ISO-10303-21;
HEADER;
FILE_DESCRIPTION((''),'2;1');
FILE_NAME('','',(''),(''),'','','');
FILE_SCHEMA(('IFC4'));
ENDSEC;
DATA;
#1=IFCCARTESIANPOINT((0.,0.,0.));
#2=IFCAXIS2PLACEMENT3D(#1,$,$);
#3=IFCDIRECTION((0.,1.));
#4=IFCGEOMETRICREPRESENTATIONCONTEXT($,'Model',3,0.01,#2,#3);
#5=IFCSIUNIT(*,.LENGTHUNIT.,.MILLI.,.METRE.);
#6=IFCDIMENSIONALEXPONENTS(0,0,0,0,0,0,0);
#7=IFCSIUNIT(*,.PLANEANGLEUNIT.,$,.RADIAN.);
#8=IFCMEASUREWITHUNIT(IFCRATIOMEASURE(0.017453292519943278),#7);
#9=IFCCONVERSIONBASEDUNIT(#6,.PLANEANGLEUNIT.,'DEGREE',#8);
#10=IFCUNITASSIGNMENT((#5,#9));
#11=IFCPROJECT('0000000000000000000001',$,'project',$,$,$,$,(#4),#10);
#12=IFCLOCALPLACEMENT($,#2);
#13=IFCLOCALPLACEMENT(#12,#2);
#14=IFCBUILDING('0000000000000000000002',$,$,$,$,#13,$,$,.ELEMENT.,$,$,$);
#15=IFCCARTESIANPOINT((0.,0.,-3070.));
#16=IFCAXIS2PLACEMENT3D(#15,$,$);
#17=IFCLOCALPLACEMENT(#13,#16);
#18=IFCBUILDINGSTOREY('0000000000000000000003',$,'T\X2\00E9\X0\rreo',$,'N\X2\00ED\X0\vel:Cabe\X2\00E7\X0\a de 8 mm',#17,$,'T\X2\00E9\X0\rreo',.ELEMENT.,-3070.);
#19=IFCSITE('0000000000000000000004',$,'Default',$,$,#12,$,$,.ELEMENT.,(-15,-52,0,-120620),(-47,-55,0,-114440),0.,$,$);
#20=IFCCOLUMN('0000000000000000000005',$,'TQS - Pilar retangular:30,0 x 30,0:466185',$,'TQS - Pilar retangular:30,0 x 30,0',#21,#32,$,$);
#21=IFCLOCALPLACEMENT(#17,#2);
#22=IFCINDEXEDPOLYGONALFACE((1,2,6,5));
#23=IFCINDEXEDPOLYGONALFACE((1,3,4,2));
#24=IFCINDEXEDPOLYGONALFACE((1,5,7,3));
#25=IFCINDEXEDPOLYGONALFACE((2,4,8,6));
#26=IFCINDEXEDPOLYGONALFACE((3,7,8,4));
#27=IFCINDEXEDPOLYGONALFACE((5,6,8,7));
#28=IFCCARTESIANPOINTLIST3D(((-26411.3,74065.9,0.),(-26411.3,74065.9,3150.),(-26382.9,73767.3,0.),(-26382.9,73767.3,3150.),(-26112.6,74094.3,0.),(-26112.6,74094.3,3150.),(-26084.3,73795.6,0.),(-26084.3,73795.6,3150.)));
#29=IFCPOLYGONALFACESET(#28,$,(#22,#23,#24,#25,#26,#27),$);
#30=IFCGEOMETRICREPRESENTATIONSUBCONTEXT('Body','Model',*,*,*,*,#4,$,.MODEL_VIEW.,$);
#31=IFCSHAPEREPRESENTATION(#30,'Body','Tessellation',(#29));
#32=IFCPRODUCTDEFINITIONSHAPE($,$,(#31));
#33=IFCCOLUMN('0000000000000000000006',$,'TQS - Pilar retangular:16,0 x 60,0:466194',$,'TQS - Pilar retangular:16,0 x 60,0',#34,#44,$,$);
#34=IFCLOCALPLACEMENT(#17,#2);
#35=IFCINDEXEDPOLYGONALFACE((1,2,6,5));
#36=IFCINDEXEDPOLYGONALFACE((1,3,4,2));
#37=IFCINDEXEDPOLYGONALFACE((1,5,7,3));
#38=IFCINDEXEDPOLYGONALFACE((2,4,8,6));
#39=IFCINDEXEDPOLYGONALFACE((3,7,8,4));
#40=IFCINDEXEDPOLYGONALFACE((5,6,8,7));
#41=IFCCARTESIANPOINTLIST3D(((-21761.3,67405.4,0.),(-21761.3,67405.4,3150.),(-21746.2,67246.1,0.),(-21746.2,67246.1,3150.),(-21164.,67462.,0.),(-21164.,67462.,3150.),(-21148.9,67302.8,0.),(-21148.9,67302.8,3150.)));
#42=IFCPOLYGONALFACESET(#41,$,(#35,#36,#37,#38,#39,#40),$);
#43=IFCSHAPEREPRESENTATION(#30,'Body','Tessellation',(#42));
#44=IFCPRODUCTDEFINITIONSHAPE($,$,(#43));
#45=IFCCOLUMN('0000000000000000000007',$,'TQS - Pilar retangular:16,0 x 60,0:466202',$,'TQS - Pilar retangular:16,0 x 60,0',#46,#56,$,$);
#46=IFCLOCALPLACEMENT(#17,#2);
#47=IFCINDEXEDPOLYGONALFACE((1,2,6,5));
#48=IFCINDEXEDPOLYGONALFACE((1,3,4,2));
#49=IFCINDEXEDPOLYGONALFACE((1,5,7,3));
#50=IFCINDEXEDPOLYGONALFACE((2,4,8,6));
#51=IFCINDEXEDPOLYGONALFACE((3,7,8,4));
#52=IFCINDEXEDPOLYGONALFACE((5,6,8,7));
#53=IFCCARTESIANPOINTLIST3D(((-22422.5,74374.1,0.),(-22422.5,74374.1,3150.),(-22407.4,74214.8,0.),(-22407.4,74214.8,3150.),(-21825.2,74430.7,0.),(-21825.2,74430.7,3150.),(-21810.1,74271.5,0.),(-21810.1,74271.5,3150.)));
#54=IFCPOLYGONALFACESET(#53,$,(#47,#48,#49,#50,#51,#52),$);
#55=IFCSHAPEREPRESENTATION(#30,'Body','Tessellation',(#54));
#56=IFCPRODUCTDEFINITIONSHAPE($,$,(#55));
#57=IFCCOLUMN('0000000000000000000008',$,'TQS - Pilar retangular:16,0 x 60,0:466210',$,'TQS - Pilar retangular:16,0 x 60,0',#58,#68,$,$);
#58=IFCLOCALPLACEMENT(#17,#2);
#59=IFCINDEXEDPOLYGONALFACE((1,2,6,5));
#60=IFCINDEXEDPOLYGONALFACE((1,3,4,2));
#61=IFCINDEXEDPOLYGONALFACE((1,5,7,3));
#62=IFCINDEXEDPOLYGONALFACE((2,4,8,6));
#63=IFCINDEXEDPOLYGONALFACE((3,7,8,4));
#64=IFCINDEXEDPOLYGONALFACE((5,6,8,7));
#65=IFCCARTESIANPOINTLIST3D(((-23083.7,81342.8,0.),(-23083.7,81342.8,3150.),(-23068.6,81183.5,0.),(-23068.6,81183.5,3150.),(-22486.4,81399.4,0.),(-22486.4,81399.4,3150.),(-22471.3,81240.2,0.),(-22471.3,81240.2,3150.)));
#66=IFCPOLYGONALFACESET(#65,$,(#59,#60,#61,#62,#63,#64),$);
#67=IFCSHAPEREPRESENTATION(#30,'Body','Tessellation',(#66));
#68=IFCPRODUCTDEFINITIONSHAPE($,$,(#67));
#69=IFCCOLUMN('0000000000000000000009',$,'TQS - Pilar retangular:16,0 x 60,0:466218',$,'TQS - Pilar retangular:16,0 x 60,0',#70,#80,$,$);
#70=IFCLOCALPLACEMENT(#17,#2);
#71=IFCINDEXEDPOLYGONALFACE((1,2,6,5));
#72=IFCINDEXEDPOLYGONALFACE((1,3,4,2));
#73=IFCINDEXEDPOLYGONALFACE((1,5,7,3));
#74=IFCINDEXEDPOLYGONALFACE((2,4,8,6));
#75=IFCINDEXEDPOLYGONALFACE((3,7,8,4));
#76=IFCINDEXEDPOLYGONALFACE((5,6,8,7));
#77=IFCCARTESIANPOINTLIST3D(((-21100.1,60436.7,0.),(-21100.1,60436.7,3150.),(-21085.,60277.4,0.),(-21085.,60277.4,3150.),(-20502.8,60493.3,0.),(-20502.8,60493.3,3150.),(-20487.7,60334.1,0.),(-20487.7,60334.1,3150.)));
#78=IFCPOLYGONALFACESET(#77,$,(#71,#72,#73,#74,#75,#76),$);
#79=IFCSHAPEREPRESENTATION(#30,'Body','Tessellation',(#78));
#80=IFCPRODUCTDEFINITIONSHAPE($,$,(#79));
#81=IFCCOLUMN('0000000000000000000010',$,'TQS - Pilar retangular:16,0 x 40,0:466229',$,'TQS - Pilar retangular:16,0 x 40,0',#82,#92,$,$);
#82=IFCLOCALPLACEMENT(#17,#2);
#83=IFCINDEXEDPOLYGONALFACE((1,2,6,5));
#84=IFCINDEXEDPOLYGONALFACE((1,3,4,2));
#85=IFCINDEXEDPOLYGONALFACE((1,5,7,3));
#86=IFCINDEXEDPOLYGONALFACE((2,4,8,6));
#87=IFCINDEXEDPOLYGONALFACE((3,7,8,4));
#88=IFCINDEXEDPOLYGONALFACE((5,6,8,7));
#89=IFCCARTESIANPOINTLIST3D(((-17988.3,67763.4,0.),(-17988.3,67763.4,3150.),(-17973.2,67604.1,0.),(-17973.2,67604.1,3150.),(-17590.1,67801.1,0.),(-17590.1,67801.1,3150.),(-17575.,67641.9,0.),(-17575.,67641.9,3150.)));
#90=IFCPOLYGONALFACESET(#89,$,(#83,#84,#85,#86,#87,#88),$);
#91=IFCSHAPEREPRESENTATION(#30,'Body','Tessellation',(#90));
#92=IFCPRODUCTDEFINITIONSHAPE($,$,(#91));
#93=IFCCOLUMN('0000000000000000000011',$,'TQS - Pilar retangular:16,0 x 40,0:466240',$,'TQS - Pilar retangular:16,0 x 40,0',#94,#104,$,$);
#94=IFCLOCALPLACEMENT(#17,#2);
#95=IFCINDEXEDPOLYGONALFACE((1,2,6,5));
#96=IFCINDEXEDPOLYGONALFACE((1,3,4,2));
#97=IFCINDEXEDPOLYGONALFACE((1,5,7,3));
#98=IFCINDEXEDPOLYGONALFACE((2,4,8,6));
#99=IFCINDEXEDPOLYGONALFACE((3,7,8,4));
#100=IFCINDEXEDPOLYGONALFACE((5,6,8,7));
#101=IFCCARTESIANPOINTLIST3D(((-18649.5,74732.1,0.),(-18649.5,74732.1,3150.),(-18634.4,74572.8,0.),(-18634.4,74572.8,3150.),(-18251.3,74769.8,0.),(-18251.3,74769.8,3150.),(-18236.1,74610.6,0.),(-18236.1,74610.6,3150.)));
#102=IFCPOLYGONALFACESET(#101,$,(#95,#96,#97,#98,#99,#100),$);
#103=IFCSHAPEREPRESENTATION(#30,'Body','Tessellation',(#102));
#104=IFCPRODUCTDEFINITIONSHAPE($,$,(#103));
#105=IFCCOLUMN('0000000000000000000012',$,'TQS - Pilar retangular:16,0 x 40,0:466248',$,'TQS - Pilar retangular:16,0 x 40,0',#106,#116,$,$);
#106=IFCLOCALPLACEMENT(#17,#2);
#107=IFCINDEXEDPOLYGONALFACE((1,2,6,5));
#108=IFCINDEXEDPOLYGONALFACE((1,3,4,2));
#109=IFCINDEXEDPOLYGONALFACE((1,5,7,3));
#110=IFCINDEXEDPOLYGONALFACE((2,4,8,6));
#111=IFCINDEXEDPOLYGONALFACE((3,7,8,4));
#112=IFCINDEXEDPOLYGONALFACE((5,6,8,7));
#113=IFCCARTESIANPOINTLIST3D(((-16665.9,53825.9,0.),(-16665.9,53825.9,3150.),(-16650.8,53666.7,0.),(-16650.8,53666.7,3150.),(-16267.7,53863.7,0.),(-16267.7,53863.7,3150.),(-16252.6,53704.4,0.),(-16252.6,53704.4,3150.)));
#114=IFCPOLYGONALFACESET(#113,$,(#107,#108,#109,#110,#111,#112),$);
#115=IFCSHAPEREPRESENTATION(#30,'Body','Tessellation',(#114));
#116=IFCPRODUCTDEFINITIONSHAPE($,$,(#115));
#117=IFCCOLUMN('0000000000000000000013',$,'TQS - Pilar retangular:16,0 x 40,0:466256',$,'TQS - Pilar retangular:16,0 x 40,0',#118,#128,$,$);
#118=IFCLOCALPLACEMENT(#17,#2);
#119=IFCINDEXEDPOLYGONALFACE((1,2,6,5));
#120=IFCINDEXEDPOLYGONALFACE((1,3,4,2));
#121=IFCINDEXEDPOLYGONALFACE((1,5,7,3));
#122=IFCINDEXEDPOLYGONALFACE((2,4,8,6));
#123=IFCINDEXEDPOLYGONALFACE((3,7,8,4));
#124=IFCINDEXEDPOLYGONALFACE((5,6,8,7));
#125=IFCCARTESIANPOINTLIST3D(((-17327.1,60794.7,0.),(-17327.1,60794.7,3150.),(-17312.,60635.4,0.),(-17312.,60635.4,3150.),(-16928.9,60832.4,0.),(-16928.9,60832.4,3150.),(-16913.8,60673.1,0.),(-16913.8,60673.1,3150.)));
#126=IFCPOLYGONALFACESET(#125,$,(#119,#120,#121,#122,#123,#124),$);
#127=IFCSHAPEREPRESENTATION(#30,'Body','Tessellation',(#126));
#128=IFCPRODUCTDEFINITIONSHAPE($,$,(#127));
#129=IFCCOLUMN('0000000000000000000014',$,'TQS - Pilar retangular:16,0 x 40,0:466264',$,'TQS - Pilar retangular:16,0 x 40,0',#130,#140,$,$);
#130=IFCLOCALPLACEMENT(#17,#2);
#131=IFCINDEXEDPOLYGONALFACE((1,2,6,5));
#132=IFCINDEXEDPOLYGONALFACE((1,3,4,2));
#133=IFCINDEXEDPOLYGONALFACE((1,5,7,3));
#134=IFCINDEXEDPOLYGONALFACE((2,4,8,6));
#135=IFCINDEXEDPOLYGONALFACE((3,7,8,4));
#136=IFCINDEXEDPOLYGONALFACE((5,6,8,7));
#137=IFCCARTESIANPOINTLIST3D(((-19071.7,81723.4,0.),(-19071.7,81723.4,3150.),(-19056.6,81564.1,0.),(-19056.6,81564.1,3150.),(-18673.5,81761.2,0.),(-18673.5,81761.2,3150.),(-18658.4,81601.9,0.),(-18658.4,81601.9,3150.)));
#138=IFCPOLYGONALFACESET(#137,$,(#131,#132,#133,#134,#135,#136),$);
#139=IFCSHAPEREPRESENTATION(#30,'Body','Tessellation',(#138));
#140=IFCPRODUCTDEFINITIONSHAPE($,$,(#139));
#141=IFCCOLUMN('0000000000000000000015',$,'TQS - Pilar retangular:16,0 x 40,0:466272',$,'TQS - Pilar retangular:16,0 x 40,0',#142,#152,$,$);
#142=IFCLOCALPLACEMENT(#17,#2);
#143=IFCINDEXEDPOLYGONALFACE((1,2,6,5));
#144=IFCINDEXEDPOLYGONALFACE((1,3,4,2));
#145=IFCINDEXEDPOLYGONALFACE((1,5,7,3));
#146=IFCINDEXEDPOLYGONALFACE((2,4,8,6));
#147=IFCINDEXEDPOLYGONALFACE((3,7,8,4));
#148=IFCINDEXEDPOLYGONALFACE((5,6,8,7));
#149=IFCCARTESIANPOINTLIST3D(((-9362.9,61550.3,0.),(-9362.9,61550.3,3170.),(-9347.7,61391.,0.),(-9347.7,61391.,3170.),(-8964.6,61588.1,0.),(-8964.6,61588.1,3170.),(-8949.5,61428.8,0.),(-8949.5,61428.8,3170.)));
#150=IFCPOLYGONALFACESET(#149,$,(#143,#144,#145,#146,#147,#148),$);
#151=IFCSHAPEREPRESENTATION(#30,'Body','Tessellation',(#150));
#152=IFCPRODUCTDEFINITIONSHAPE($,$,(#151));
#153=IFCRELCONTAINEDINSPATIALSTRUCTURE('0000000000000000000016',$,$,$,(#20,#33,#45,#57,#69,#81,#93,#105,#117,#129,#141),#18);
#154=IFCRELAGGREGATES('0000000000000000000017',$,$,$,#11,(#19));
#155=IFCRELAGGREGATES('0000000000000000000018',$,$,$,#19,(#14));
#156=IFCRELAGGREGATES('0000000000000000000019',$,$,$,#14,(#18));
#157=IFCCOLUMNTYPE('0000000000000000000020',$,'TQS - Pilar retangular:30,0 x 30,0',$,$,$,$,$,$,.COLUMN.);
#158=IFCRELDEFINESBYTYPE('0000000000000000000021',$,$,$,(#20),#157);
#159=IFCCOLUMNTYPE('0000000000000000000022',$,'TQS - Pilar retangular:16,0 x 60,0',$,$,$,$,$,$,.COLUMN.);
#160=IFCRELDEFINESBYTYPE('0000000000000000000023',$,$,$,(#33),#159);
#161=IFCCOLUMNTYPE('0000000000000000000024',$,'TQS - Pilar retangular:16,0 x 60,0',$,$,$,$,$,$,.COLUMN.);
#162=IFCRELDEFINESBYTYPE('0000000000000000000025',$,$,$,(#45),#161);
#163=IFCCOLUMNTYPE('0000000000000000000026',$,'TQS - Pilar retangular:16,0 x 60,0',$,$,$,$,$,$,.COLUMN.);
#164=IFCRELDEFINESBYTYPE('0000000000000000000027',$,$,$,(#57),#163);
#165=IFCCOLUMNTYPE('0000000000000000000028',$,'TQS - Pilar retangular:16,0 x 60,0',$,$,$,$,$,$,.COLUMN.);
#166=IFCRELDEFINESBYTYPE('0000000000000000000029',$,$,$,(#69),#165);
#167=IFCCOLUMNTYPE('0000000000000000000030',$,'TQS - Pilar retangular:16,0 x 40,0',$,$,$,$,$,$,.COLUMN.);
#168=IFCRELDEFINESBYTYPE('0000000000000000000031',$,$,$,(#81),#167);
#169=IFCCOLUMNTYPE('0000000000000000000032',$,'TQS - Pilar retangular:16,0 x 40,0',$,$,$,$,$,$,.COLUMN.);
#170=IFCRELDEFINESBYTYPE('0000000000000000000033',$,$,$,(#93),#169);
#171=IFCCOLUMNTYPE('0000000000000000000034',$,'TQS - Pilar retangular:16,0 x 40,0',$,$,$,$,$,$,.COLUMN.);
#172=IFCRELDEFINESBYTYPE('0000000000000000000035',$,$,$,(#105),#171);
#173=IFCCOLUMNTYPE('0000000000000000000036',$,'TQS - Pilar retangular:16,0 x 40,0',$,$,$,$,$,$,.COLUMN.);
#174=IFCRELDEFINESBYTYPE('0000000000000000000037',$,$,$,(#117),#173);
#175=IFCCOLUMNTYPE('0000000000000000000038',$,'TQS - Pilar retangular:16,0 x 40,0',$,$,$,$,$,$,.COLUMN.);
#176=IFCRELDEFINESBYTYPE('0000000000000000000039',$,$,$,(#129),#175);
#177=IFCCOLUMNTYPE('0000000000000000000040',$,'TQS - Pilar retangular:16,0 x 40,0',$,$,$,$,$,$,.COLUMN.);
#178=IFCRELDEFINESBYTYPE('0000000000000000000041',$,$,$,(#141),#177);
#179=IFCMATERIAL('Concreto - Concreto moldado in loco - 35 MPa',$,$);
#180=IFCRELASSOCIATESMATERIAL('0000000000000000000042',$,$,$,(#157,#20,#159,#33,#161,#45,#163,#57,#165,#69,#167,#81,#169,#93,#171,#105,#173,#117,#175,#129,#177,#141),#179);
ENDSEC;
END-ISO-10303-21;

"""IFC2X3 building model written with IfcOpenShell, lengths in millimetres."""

from ifc_helpers import new_model, entity, si_unit, converted_unit, direction, frame, origin, origin_2d_with_axis, place, context, subcontext, project, spatial, rectangle, extrude, source, transform, mapped, material, type_object, type_shapes, element, save


model = new_model("IFC2X3")

# Units and contexts
model_context = context("Model", 3, precision=0.01, world=origin(), true_north=direction((0.0, 1.0)))
body_context = subcontext(model_context, "Body", "Model", "MODEL_VIEW")
ifc_project = project(units=[si_unit("LENGTHUNIT", "METRE", prefix="MILLI"), converted_unit("PLANEANGLEUNIT", "DEGREE", entity("IfcRatioMeasure", 0.017453292519943278), si_unit("PLANEANGLEUNIT", "RADIAN"), dimensions=[0, 0, 0, 0, 0, 0, 0])], contexts=[model_context])

# Site, building, storey
site_placement = place(None, origin())
site = spatial("IfcSite", under=ifc_project, at=site_placement, Name="Default", CompositionType="ELEMENT", RefLatitude=(-15, -52, 0, -120620), RefLongitude=(-47, -55, 0, -114440), RefElevation=0.0)
building_placement = place(site_placement, origin())
building = spatial("IfcBuilding", under=site, at=building_placement, CompositionType="ELEMENT")
storey_placement = place(building_placement, frame((0.0, 0.0, -3070.0)))
storey = spatial("IfcBuildingStorey", under=building, at=storey_placement, Name="Térreo", ObjectType="Nível:Cabeça de 8 mm", LongName="Térreo", CompositionType="ELEMENT", Elevation=-3070.0)

# Columns
ifc_material = material(Name="Concreto - Concreto moldado in loco - 35 MPa")
column_type_1 = type_object("IfcColumnType", Name="TQS - Pilar retangular:30,0 x 30,0", PredefinedType="COLUMN", material=ifc_material)
shared_shape_1 = source(origin(), body_context, "Body", "SweptSolid", [
    extrude(rectangle(XDim=300.0, YDim=300.0, at=origin_2d_with_axis()), frame((-26247.8, 73930.8, -3070.0), z_axis=(0.0, 0.0, 1.0), x_axis=(-0.995529, -0.094456, 0.0)), (0.0, 0.0, 1.0), 3150.0),
])
type_shapes(column_type_1, [shared_shape_1])
column_1_placement = place(storey_placement, frame((0.0, 0.0, 3070.0)))
element("IfcColumn", 1, at=column_1_placement, inside=storey, type_object=column_type_1, material=ifc_material, Name="TQS - Pilar retangular:30,0 x 30,0:466185", ObjectType="TQS - Pilar retangular:30,0 x 30,0", context=body_context, shape_type="MappedRepresentation", body=[
    mapped(shared_shape_1, transform((0.0, 0.0, 0.0), scale=1.0)),
])
column_type_2 = type_object("IfcColumnType", Name="TQS - Pilar retangular:16,0 x 60,0", PredefinedType="COLUMN", material=ifc_material)
shared_shape_2 = source(origin(), body_context, "Body", "SweptSolid", [
    extrude(rectangle(XDim=600.0, YDim=160.0, at=origin_2d_with_axis()), frame((-21455.1, 67354.1, -3070.0), z_axis=(0.0, 0.0, 1.0), x_axis=(-0.995529, -0.094456, 0.0)), (0.0, 0.0, 1.0), 3150.0),
])
type_shapes(column_type_2, [shared_shape_2])
column_2_placement = place(storey_placement, frame((0.0, 0.0, 3070.0)))
element("IfcColumn", 2, at=column_2_placement, inside=storey, type_object=column_type_2, material=ifc_material, Name="TQS - Pilar retangular:16,0 x 60,0:466194", ObjectType="TQS - Pilar retangular:16,0 x 60,0", context=body_context, shape_type="MappedRepresentation", body=[
    mapped(shared_shape_2, transform((0.0, 0.0, 0.0), scale=1.0)),
])
column_type_3 = type_object("IfcColumnType", Name="TQS - Pilar retangular:16,0 x 60,0", PredefinedType="COLUMN", material=ifc_material)
shared_shape_3 = source(origin(), body_context, "Body", "SweptSolid", [
    extrude(rectangle(XDim=600.0, YDim=160.0, at=origin_2d_with_axis()), frame((-22116.3, 74322.8, -3070.0), z_axis=(0.0, 0.0, 1.0), x_axis=(-0.995529, -0.094456, 0.0)), (0.0, 0.0, 1.0), 3150.0),
])
type_shapes(column_type_3, [shared_shape_3])
column_3_placement = place(storey_placement, frame((0.0, 0.0, 3070.0)))
element("IfcColumn", 3, at=column_3_placement, inside=storey, type_object=column_type_3, material=ifc_material, Name="TQS - Pilar retangular:16,0 x 60,0:466202", ObjectType="TQS - Pilar retangular:16,0 x 60,0", context=body_context, shape_type="MappedRepresentation", body=[
    mapped(shared_shape_3, transform((0.0, 0.0, 0.0), scale=1.0)),
])
column_type_4 = type_object("IfcColumnType", Name="TQS - Pilar retangular:16,0 x 60,0", PredefinedType="COLUMN", material=ifc_material)
shared_shape_4 = source(origin(), body_context, "Body", "SweptSolid", [
    extrude(rectangle(XDim=600.0, YDim=160.0, at=origin_2d_with_axis()), frame((-22777.5, 81291.5, -3070.0), z_axis=(0.0, 0.0, 1.0), x_axis=(-0.995529, -0.094456, 0.0)), (0.0, 0.0, 1.0), 3150.0),
])
type_shapes(column_type_4, [shared_shape_4])
column_4_placement = place(storey_placement, frame((0.0, 0.0, 3070.0)))
element("IfcColumn", 4, at=column_4_placement, inside=storey, type_object=column_type_4, material=ifc_material, Name="TQS - Pilar retangular:16,0 x 60,0:466210", ObjectType="TQS - Pilar retangular:16,0 x 60,0", context=body_context, shape_type="MappedRepresentation", body=[
    mapped(shared_shape_4, transform((0.0, 0.0, 0.0), scale=1.0)),
])
column_type_5 = type_object("IfcColumnType", Name="TQS - Pilar retangular:16,0 x 60,0", PredefinedType="COLUMN", material=ifc_material)
shared_shape_5 = source(origin(), body_context, "Body", "SweptSolid", [
    extrude(rectangle(XDim=600.0, YDim=160.0, at=origin_2d_with_axis()), frame((-20793.9, 60385.4, -3070.0), z_axis=(0.0, 0.0, 1.0), x_axis=(-0.995529, -0.094456, 0.0)), (0.0, 0.0, 1.0), 3150.0),
])
type_shapes(column_type_5, [shared_shape_5])
column_5_placement = place(storey_placement, frame((0.0, 0.0, 3070.0)))
element("IfcColumn", 5, at=column_5_placement, inside=storey, type_object=column_type_5, material=ifc_material, Name="TQS - Pilar retangular:16,0 x 60,0:466218", ObjectType="TQS - Pilar retangular:16,0 x 60,0", context=body_context, shape_type="MappedRepresentation", body=[
    mapped(shared_shape_5, transform((0.0, 0.0, 0.0), scale=1.0)),
])
column_type_6 = type_object("IfcColumnType", Name="TQS - Pilar retangular:16,0 x 40,0", PredefinedType="COLUMN", material=ifc_material)
shared_shape_6 = source(origin(), body_context, "Body", "SweptSolid", [
    extrude(rectangle(XDim=400.0, YDim=160.0, at=origin_2d_with_axis()), frame((-17781.6, 67702.6, -3070.0), z_axis=(0.0, 0.0, 1.0), x_axis=(-0.995529, -0.094456, 0.0)), (0.0, 0.0, 1.0), 3150.0),
])
type_shapes(column_type_6, [shared_shape_6])
column_6_placement = place(storey_placement, frame((0.0, 0.0, 3070.0)))
element("IfcColumn", 6, at=column_6_placement, inside=storey, type_object=column_type_6, material=ifc_material, Name="TQS - Pilar retangular:16,0 x 40,0:466229", ObjectType="TQS - Pilar retangular:16,0 x 40,0", context=body_context, shape_type="MappedRepresentation", body=[
    mapped(shared_shape_6, transform((0.0, 0.0, 0.0), scale=1.0)),
])
column_type_7 = type_object("IfcColumnType", Name="TQS - Pilar retangular:16,0 x 40,0", PredefinedType="COLUMN", material=ifc_material)
shared_shape_7 = source(origin(), body_context, "Body", "SweptSolid", [
    extrude(rectangle(XDim=400.0, YDim=160.0, at=origin_2d_with_axis()), frame((-18442.8, 74671.3, -3070.0), z_axis=(0.0, 0.0, 1.0), x_axis=(-0.995529, -0.094456, 0.0)), (0.0, 0.0, 1.0), 3150.0),
])
type_shapes(column_type_7, [shared_shape_7])
column_7_placement = place(storey_placement, frame((0.0, 0.0, 3070.0)))
element("IfcColumn", 7, at=column_7_placement, inside=storey, type_object=column_type_7, material=ifc_material, Name="TQS - Pilar retangular:16,0 x 40,0:466240", ObjectType="TQS - Pilar retangular:16,0 x 40,0", context=body_context, shape_type="MappedRepresentation", body=[
    mapped(shared_shape_7, transform((0.0, 0.0, 0.0), scale=1.0)),
])
column_type_8 = type_object("IfcColumnType", Name="TQS - Pilar retangular:16,0 x 40,0", PredefinedType="COLUMN", material=ifc_material)
shared_shape_8 = source(origin(), body_context, "Body", "SweptSolid", [
    extrude(rectangle(XDim=400.0, YDim=160.0, at=origin_2d_with_axis()), frame((-16459.2, 53765.2, -3070.0), z_axis=(0.0, 0.0, 1.0), x_axis=(-0.995529, -0.094456, 0.0)), (0.0, 0.0, 1.0), 3150.0),
])
type_shapes(column_type_8, [shared_shape_8])
column_8_placement = place(storey_placement, frame((0.0, 0.0, 3070.0)))
element("IfcColumn", 8, at=column_8_placement, inside=storey, type_object=column_type_8, material=ifc_material, Name="TQS - Pilar retangular:16,0 x 40,0:466248", ObjectType="TQS - Pilar retangular:16,0 x 40,0", context=body_context, shape_type="MappedRepresentation", body=[
    mapped(shared_shape_8, transform((0.0, 0.0, 0.0), scale=1.0)),
])
column_type_9 = type_object("IfcColumnType", Name="TQS - Pilar retangular:16,0 x 40,0", PredefinedType="COLUMN", material=ifc_material)
shared_shape_9 = source(origin(), body_context, "Body", "SweptSolid", [
    extrude(rectangle(XDim=400.0, YDim=160.0, at=origin_2d_with_axis()), frame((-17120.4, 60733.9, -3070.0), z_axis=(0.0, 0.0, 1.0), x_axis=(-0.995529, -0.094456, 0.0)), (0.0, 0.0, 1.0), 3150.0),
])
type_shapes(column_type_9, [shared_shape_9])
column_9_placement = place(storey_placement, frame((0.0, 0.0, 3070.0)))
element("IfcColumn", 9, at=column_9_placement, inside=storey, type_object=column_type_9, material=ifc_material, Name="TQS - Pilar retangular:16,0 x 40,0:466256", ObjectType="TQS - Pilar retangular:16,0 x 40,0", context=body_context, shape_type="MappedRepresentation", body=[
    mapped(shared_shape_9, transform((0.0, 0.0, 0.0), scale=1.0)),
])
column_type_10 = type_object("IfcColumnType", Name="TQS - Pilar retangular:16,0 x 40,0", PredefinedType="COLUMN", material=ifc_material)
shared_shape_10 = source(origin(), body_context, "Body", "SweptSolid", [
    extrude(rectangle(XDim=400.0, YDim=160.0, at=origin_2d_with_axis()), frame((-18865.1, 81662.7, -3070.0), z_axis=(0.0, 0.0, 1.0), x_axis=(-0.995529, -0.094456, 0.0)), (0.0, 0.0, 1.0), 3150.0),
])
type_shapes(column_type_10, [shared_shape_10])
column_10_placement = place(storey_placement, frame((0.0, 0.0, 3070.0)))
element("IfcColumn", 10, at=column_10_placement, inside=storey, type_object=column_type_10, material=ifc_material, Name="TQS - Pilar retangular:16,0 x 40,0:466264", ObjectType="TQS - Pilar retangular:16,0 x 40,0", context=body_context, shape_type="MappedRepresentation", body=[
    mapped(shared_shape_10, transform((0.0, 0.0, 0.0), scale=1.0)),
])
column_type_11 = type_object("IfcColumnType", Name="TQS - Pilar retangular:16,0 x 40,0", PredefinedType="COLUMN", material=ifc_material)
shared_shape_11 = source(origin(), body_context, "Body", "SweptSolid", [
    extrude(rectangle(XDim=400.0, YDim=160.0, at=origin_2d_with_axis()), frame((-9156.2, 61489.5, -3070.0), z_axis=(0.0, 0.0, 1.0), x_axis=(-0.995529, -0.094456, 0.0)), (0.0, 0.0, 1.0), 3170.0),
])
type_shapes(column_type_11, [shared_shape_11])
column_11_placement = place(storey_placement, frame((0.0, 0.0, 3070.0)))
element("IfcColumn", 11, at=column_11_placement, inside=storey, type_object=column_type_11, material=ifc_material, Name="TQS - Pilar retangular:16,0 x 40,0:466272", ObjectType="TQS - Pilar retangular:16,0 x 40,0", context=body_context, shape_type="MappedRepresentation", body=[
    mapped(shared_shape_11, transform((0.0, 0.0, 0.0), scale=1.0)),
])

save(model, "model.ifc")
